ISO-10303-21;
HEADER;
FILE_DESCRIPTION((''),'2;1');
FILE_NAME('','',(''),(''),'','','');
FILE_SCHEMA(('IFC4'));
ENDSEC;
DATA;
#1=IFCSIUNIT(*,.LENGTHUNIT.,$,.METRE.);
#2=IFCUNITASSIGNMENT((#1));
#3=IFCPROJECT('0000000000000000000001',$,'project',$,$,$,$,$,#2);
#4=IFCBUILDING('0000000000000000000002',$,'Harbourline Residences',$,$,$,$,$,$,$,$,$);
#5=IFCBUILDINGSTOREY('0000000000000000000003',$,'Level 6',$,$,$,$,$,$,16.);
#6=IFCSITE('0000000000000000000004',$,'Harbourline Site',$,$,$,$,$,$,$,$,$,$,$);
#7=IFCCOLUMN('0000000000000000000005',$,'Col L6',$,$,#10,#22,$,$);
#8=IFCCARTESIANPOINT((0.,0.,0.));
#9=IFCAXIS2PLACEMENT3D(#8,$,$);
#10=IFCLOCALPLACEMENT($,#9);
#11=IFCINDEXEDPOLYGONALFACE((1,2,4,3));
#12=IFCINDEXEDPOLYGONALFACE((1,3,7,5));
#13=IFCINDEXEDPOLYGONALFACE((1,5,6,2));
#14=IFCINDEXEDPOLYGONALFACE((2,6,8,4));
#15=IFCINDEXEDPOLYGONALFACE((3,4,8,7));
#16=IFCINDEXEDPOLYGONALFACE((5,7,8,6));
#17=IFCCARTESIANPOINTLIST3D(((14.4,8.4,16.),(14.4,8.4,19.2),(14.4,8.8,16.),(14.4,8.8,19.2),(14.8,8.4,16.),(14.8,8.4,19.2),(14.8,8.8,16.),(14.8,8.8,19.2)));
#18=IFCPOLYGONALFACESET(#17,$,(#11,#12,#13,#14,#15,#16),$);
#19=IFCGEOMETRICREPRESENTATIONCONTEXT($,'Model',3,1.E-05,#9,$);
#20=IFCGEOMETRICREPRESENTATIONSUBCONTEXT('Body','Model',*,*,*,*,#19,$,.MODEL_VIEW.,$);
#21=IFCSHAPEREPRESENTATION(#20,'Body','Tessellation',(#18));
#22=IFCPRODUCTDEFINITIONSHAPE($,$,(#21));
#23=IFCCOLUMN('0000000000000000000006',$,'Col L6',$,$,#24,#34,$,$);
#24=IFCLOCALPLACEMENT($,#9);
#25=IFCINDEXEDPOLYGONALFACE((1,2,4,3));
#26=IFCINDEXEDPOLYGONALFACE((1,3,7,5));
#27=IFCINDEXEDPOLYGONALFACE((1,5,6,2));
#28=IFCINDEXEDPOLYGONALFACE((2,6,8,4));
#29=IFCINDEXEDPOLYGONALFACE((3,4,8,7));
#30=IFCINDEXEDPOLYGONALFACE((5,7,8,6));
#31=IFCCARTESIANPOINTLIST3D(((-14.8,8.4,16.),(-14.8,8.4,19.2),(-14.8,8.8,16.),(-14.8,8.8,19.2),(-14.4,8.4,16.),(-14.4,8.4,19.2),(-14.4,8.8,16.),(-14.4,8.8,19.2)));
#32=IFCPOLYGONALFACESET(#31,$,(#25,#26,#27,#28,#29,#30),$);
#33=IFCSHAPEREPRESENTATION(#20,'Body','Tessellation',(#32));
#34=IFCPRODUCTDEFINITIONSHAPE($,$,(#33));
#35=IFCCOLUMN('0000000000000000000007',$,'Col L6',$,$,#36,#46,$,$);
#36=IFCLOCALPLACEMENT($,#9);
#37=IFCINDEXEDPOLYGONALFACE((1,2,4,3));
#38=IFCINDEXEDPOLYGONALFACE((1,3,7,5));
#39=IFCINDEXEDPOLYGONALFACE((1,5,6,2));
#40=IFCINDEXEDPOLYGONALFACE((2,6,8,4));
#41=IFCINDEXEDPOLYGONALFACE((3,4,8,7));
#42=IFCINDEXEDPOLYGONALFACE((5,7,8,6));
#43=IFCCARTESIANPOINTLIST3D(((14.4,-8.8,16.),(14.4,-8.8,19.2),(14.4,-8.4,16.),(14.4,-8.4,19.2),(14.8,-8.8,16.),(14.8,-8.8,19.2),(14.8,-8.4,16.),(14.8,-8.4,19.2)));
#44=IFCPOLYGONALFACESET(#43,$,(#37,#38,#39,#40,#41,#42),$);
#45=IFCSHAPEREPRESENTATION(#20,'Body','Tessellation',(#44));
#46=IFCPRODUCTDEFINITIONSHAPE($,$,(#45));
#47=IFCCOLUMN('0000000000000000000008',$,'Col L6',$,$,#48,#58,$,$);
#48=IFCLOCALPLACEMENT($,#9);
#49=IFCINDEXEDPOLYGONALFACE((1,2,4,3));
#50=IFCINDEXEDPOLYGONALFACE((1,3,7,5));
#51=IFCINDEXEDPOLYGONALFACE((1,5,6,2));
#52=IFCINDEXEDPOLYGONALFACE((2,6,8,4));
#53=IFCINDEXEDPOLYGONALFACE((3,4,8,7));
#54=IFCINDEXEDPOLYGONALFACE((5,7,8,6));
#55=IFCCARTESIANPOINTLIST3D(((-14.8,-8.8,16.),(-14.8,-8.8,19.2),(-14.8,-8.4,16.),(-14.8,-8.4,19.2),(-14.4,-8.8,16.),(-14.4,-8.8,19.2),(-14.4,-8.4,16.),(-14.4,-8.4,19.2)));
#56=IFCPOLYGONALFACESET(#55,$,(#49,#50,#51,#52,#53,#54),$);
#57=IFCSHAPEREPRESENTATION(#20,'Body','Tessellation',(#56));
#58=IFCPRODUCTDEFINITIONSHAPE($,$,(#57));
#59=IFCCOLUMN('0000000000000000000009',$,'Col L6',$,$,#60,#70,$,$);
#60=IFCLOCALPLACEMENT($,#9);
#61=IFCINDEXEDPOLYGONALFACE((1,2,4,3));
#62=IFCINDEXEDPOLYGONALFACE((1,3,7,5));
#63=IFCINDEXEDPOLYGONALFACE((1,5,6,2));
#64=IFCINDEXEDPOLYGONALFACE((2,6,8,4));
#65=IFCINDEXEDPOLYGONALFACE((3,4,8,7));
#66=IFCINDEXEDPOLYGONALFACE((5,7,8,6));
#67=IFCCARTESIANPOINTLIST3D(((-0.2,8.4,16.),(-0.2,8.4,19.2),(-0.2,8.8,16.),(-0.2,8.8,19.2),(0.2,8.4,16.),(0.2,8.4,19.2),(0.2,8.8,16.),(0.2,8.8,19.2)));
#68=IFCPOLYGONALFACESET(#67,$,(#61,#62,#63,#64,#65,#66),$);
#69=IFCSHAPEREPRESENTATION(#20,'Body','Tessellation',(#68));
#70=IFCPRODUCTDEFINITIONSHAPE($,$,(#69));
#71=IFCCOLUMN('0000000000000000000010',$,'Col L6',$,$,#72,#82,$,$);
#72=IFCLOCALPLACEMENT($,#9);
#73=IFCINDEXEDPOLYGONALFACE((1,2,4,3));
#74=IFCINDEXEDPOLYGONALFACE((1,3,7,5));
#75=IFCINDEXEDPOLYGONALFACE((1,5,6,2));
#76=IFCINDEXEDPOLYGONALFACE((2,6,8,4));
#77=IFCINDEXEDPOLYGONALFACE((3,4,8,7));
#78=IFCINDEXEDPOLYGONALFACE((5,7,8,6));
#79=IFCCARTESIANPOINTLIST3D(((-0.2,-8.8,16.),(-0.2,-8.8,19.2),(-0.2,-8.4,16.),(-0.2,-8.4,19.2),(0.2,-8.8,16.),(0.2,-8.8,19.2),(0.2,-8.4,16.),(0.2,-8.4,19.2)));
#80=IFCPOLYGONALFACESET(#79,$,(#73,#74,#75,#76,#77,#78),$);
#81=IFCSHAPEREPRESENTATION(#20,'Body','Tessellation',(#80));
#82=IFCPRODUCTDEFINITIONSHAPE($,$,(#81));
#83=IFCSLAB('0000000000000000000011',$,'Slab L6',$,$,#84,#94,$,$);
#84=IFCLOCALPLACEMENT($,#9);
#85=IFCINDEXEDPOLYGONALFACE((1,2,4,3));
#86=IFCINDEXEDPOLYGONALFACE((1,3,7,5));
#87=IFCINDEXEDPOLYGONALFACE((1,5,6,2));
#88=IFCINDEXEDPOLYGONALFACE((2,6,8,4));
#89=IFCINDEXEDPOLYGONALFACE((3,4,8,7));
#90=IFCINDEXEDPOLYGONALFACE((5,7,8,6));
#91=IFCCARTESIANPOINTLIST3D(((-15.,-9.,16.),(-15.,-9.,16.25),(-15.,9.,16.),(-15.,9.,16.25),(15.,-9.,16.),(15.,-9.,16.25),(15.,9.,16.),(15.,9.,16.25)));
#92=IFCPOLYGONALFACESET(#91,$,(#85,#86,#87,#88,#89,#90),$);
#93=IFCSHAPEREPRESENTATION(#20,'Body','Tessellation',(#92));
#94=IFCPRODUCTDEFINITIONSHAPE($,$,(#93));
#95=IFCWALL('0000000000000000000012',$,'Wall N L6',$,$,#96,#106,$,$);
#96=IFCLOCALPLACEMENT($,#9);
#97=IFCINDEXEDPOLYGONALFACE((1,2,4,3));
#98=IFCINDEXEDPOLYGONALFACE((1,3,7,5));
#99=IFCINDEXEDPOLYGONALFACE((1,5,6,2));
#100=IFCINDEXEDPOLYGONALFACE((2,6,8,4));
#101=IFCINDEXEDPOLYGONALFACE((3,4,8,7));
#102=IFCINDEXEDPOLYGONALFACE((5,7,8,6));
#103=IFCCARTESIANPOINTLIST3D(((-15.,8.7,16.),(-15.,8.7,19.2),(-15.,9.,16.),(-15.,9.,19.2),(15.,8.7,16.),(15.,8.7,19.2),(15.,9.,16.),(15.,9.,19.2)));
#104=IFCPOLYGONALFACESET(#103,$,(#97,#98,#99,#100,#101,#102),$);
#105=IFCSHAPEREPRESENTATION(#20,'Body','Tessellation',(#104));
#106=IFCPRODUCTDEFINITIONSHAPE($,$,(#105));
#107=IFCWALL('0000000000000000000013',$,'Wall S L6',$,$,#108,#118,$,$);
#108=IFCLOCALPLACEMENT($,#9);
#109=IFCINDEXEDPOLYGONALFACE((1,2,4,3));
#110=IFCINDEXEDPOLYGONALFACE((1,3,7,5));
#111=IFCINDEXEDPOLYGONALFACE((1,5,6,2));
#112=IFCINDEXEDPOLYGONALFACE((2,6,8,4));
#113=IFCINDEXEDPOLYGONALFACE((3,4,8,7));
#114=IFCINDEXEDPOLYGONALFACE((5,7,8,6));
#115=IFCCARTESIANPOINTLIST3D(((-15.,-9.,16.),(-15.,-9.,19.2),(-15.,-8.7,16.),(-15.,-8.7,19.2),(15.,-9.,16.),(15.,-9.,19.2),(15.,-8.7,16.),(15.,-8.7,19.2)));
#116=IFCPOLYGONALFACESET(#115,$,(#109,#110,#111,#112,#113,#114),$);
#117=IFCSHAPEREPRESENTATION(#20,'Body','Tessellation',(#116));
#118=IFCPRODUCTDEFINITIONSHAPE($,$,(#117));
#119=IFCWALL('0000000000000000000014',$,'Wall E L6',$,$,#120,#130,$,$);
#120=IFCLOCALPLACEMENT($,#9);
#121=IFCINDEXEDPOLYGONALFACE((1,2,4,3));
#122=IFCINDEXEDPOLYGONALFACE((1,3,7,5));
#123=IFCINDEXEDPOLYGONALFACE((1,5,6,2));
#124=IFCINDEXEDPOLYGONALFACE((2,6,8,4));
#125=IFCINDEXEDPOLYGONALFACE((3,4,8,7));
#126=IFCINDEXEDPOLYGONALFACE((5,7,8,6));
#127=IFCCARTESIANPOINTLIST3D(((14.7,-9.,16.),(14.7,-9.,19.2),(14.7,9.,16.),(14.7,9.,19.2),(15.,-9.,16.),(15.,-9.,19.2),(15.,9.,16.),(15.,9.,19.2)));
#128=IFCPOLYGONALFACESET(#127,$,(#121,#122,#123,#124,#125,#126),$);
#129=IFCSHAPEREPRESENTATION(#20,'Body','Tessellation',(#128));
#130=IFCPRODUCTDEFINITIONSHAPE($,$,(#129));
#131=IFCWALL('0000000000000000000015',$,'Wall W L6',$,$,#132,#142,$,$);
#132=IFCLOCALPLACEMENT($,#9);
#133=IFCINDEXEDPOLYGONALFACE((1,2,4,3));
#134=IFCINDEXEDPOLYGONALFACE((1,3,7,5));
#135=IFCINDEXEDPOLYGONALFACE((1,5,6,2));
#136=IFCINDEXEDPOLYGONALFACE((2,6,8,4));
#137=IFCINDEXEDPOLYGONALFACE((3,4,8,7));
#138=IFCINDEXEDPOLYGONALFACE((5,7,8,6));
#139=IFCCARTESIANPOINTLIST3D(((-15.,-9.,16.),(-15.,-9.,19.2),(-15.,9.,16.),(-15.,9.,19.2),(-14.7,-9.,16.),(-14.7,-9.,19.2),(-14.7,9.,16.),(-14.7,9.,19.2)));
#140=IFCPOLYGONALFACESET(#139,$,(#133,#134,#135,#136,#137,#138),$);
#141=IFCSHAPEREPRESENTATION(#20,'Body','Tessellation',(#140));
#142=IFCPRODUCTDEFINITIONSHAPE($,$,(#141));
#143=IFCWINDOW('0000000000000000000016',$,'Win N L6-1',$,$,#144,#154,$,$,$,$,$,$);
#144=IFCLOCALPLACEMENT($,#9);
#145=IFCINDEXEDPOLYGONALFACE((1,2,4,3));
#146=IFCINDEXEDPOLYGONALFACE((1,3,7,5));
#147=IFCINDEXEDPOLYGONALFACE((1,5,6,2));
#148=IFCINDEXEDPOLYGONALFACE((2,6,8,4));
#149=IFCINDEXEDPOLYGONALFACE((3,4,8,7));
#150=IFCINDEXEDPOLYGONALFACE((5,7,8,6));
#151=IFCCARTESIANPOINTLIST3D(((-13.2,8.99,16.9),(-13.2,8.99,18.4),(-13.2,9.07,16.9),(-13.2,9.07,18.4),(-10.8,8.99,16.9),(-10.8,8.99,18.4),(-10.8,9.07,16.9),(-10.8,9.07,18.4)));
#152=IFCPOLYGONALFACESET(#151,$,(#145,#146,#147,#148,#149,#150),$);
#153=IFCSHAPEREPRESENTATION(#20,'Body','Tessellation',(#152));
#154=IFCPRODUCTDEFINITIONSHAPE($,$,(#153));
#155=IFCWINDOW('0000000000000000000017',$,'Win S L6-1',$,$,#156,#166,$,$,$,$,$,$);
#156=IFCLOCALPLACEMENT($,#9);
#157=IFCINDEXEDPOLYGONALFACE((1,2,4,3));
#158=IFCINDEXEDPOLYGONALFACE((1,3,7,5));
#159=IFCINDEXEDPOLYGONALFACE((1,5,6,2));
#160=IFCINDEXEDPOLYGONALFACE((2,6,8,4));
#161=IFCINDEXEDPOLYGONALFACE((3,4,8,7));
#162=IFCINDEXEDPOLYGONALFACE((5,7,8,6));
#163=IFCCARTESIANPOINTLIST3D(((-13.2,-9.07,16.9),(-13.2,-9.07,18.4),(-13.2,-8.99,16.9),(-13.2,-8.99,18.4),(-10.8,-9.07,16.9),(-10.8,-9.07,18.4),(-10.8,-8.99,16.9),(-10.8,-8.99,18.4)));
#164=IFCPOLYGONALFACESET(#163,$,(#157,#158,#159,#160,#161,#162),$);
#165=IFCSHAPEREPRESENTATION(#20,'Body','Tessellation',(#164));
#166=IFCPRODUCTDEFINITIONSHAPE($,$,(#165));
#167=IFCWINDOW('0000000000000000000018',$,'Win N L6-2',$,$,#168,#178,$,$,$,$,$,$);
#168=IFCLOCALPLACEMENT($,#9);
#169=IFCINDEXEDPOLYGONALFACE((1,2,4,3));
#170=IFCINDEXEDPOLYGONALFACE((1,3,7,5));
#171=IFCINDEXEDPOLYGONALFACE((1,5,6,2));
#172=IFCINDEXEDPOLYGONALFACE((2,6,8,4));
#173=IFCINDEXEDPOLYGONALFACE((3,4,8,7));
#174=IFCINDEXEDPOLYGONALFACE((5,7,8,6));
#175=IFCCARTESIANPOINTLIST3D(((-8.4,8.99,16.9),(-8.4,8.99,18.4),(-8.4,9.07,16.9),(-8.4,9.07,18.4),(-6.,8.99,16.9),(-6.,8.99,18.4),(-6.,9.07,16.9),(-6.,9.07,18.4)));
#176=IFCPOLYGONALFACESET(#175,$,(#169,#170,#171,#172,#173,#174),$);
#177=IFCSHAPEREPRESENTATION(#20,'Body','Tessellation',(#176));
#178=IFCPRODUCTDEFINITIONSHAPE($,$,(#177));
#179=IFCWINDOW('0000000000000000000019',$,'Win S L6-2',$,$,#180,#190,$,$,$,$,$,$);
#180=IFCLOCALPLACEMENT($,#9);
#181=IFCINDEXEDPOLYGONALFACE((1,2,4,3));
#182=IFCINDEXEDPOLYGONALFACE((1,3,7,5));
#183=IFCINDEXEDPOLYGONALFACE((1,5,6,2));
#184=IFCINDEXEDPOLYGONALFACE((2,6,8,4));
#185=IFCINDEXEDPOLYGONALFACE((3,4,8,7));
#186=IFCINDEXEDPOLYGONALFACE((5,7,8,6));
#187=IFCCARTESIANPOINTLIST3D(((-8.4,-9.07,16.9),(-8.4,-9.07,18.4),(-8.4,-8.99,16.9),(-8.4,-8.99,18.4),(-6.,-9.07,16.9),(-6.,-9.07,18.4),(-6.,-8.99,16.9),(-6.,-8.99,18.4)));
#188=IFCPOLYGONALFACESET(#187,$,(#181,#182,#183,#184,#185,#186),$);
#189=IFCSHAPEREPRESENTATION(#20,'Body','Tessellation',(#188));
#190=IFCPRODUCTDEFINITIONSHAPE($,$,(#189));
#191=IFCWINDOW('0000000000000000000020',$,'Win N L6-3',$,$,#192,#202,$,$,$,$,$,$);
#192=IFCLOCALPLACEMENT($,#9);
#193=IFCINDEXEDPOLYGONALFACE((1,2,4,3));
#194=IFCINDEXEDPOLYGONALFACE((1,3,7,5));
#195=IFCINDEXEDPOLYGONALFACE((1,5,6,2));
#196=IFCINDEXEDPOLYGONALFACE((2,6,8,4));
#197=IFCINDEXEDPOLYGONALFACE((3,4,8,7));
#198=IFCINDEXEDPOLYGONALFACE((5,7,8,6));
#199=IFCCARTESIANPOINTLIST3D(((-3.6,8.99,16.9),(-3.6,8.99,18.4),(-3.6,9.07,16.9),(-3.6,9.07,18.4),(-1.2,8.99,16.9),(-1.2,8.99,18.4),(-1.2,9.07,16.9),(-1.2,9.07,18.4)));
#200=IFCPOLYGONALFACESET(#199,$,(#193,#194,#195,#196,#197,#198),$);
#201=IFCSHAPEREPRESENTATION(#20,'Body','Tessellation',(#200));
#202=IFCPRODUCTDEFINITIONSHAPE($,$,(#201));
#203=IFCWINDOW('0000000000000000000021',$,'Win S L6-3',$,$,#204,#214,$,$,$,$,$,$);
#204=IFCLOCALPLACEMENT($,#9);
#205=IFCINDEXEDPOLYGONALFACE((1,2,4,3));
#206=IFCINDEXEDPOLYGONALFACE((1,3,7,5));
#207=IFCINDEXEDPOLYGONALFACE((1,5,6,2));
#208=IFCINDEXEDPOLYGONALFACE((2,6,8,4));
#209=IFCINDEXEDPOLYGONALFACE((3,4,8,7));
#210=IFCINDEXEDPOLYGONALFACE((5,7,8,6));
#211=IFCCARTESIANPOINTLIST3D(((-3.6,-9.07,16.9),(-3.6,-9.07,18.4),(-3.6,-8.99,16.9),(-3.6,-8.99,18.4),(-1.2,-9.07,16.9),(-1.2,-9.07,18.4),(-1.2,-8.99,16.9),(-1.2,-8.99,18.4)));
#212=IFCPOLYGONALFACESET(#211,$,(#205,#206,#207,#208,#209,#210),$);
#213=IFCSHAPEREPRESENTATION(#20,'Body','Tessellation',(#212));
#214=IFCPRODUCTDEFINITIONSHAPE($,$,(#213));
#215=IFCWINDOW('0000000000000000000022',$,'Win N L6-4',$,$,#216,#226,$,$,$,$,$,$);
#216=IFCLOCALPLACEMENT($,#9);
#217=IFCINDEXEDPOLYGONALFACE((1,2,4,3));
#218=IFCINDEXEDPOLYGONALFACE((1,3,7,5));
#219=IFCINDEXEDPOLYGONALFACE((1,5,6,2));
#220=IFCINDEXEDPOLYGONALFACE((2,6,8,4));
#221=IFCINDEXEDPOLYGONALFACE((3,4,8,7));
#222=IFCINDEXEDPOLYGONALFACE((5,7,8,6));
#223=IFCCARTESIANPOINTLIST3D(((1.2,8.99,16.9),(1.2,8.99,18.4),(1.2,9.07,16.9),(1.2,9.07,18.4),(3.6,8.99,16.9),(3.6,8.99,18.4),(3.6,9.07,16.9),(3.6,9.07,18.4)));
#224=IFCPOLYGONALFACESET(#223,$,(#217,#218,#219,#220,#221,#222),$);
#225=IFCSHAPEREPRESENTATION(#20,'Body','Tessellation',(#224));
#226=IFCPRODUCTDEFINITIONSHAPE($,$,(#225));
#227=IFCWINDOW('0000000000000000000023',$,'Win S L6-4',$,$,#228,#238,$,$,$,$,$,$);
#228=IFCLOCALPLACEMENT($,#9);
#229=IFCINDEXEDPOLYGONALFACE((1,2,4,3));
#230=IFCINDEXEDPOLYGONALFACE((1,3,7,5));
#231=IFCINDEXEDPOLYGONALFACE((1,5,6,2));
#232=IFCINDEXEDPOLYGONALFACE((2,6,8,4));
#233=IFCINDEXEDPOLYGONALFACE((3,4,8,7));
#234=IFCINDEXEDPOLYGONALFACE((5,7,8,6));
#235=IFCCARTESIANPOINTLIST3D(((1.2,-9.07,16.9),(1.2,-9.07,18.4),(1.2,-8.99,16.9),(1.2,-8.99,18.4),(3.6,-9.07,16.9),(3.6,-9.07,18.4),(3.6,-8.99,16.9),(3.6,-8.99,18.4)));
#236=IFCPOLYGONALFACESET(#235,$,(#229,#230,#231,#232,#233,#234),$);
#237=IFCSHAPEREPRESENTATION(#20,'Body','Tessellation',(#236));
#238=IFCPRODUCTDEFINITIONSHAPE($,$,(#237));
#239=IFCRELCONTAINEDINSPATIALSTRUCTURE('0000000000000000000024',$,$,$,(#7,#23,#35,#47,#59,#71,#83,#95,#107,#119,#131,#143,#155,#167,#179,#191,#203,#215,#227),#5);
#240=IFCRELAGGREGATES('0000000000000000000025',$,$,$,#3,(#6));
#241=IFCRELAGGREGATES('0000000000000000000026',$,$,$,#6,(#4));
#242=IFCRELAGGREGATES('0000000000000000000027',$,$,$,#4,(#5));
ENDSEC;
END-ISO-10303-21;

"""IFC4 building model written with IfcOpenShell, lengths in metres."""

from ifc_helpers import new_model, si_unit, frame, frame_2d, origin, origin_2d, context, subcontext, project, spatial, rectangle, extrude, element, save


model = new_model("IFC4")

# Units and contexts
model_context = context("Model", 3, precision=1e-05, world=origin())
body_context = subcontext(model_context, "Body", "Model", "MODEL_VIEW")
ifc_project = project(units=[si_unit("LENGTHUNIT", "METRE")])

# Site, building, storey
site = spatial("IfcSite", under=ifc_project, Name="Harbourline Site")
building = spatial("IfcBuilding", under=site, Name="Harbourline Residences")
storey = spatial("IfcBuildingStorey", under=building, Name="Level 6", Elevation=16.0)

# Columns
element("IfcColumn", 1, inside=storey, Name="Col L6", context=body_context, shape_type="SweptSolid", body=[
    extrude(rectangle(XDim=0.4, YDim=0.4, at=frame_2d((14.6, 8.6))), frame((0.0, 0.0, 16.0)), (0.0, 0.0, 1.0), 3.2),
])
element("IfcColumn", 2, inside=storey, Name="Col L6", context=body_context, shape_type="SweptSolid", body=[
    extrude(rectangle(XDim=0.4, YDim=0.4, at=frame_2d((-14.6, 8.6))), frame((0.0, 0.0, 16.0)), (0.0, 0.0, 1.0), 3.2),
])
element("IfcColumn", 3, inside=storey, Name="Col L6", context=body_context, shape_type="SweptSolid", body=[
    extrude(rectangle(XDim=0.4, YDim=0.4, at=frame_2d((14.6, -8.6))), frame((0.0, 0.0, 16.0)), (0.0, 0.0, 1.0), 3.2),
])
element("IfcColumn", 4, inside=storey, Name="Col L6", context=body_context, shape_type="SweptSolid", body=[
    extrude(rectangle(XDim=0.4, YDim=0.4, at=frame_2d((-14.6, -8.6))), frame((0.0, 0.0, 16.0)), (0.0, 0.0, 1.0), 3.2),
])
element("IfcColumn", 5, inside=storey, Name="Col L6", context=body_context, shape_type="SweptSolid", body=[
    extrude(rectangle(XDim=0.4, YDim=0.4, at=frame_2d((0.0, 8.6))), frame((0.0, 0.0, 16.0)), (0.0, 0.0, 1.0), 3.2),
])
element("IfcColumn", 6, inside=storey, Name="Col L6", context=body_context, shape_type="SweptSolid", body=[
    extrude(rectangle(XDim=0.4, YDim=0.4, at=frame_2d((0.0, -8.6))), frame((0.0, 0.0, 16.0)), (0.0, 0.0, 1.0), 3.2),
])

# Slab
element("IfcSlab", 7, inside=storey, Name="Slab L6", context=body_context, shape_type="SweptSolid", body=[
    extrude(rectangle(XDim=30.0, YDim=18.0, at=origin_2d()), frame((0.0, 0.0, 16.0)), (0.0, 0.0, 1.0), 0.25),
])

# Walls
element("IfcWall", 8, inside=storey, Name="Wall N L6", context=body_context, shape_type="SweptSolid", body=[
    extrude(rectangle(XDim=30.0, YDim=0.3, at=frame_2d((0.0, 8.85))), frame((0.0, 0.0, 16.0)), (0.0, 0.0, 1.0), 3.2),
])
element("IfcWall", 9, inside=storey, Name="Wall S L6", context=body_context, shape_type="SweptSolid", body=[
    extrude(rectangle(XDim=30.0, YDim=0.3, at=frame_2d((0.0, -8.85))), frame((0.0, 0.0, 16.0)), (0.0, 0.0, 1.0), 3.2),
])
element("IfcWall", 10, inside=storey, Name="Wall E L6", context=body_context, shape_type="SweptSolid", body=[
    extrude(rectangle(XDim=0.3, YDim=18.0, at=frame_2d((14.85, 0.0))), frame((0.0, 0.0, 16.0)), (0.0, 0.0, 1.0), 3.2),
])
element("IfcWall", 11, inside=storey, Name="Wall W L6", context=body_context, shape_type="SweptSolid", body=[
    extrude(rectangle(XDim=0.3, YDim=18.0, at=frame_2d((-14.85, 0.0))), frame((0.0, 0.0, 16.0)), (0.0, 0.0, 1.0), 3.2),
])

# Windows
element("IfcWindow", 12, inside=storey, Name="Win N L6-1", context=body_context, shape_type="SweptSolid", body=[
    extrude(rectangle(XDim=2.4, YDim=0.08, at=frame_2d((-12.0, 9.03))), frame((0.0, 0.0, 16.9)), (0.0, 0.0, 1.0), 1.5),
])
element("IfcWindow", 13, inside=storey, Name="Win S L6-1", context=body_context, shape_type="SweptSolid", body=[
    extrude(rectangle(XDim=2.4, YDim=0.08, at=frame_2d((-12.0, -9.03))), frame((0.0, 0.0, 16.9)), (0.0, 0.0, 1.0), 1.5),
])
element("IfcWindow", 14, inside=storey, Name="Win N L6-2", context=body_context, shape_type="SweptSolid", body=[
    extrude(rectangle(XDim=2.4, YDim=0.08, at=frame_2d((-7.2, 9.03))), frame((0.0, 0.0, 16.9)), (0.0, 0.0, 1.0), 1.5),
])
element("IfcWindow", 15, inside=storey, Name="Win S L6-2", context=body_context, shape_type="SweptSolid", body=[
    extrude(rectangle(XDim=2.4, YDim=0.08, at=frame_2d((-7.2, -9.03))), frame((0.0, 0.0, 16.9)), (0.0, 0.0, 1.0), 1.5),
])
element("IfcWindow", 16, inside=storey, Name="Win N L6-3", context=body_context, shape_type="SweptSolid", body=[
    extrude(rectangle(XDim=2.4, YDim=0.08, at=frame_2d((-2.4, 9.03))), frame((0.0, 0.0, 16.9)), (0.0, 0.0, 1.0), 1.5),
])
element("IfcWindow", 17, inside=storey, Name="Win S L6-3", context=body_context, shape_type="SweptSolid", body=[
    extrude(rectangle(XDim=2.4, YDim=0.08, at=frame_2d((-2.4, -9.03))), frame((0.0, 0.0, 16.9)), (0.0, 0.0, 1.0), 1.5),
])
element("IfcWindow", 18, inside=storey, Name="Win N L6-4", context=body_context, shape_type="SweptSolid", body=[
    extrude(rectangle(XDim=2.4, YDim=0.08, at=frame_2d((2.4, 9.03))), frame((0.0, 0.0, 16.9)), (0.0, 0.0, 1.0), 1.5),
])
element("IfcWindow", 19, inside=storey, Name="Win S L6-4", context=body_context, shape_type="SweptSolid", body=[
    extrude(rectangle(XDim=2.4, YDim=0.08, at=frame_2d((2.4, -9.03))), frame((0.0, 0.0, 16.9)), (0.0, 0.0, 1.0), 1.5),
])

save(model, "model.ifc")
